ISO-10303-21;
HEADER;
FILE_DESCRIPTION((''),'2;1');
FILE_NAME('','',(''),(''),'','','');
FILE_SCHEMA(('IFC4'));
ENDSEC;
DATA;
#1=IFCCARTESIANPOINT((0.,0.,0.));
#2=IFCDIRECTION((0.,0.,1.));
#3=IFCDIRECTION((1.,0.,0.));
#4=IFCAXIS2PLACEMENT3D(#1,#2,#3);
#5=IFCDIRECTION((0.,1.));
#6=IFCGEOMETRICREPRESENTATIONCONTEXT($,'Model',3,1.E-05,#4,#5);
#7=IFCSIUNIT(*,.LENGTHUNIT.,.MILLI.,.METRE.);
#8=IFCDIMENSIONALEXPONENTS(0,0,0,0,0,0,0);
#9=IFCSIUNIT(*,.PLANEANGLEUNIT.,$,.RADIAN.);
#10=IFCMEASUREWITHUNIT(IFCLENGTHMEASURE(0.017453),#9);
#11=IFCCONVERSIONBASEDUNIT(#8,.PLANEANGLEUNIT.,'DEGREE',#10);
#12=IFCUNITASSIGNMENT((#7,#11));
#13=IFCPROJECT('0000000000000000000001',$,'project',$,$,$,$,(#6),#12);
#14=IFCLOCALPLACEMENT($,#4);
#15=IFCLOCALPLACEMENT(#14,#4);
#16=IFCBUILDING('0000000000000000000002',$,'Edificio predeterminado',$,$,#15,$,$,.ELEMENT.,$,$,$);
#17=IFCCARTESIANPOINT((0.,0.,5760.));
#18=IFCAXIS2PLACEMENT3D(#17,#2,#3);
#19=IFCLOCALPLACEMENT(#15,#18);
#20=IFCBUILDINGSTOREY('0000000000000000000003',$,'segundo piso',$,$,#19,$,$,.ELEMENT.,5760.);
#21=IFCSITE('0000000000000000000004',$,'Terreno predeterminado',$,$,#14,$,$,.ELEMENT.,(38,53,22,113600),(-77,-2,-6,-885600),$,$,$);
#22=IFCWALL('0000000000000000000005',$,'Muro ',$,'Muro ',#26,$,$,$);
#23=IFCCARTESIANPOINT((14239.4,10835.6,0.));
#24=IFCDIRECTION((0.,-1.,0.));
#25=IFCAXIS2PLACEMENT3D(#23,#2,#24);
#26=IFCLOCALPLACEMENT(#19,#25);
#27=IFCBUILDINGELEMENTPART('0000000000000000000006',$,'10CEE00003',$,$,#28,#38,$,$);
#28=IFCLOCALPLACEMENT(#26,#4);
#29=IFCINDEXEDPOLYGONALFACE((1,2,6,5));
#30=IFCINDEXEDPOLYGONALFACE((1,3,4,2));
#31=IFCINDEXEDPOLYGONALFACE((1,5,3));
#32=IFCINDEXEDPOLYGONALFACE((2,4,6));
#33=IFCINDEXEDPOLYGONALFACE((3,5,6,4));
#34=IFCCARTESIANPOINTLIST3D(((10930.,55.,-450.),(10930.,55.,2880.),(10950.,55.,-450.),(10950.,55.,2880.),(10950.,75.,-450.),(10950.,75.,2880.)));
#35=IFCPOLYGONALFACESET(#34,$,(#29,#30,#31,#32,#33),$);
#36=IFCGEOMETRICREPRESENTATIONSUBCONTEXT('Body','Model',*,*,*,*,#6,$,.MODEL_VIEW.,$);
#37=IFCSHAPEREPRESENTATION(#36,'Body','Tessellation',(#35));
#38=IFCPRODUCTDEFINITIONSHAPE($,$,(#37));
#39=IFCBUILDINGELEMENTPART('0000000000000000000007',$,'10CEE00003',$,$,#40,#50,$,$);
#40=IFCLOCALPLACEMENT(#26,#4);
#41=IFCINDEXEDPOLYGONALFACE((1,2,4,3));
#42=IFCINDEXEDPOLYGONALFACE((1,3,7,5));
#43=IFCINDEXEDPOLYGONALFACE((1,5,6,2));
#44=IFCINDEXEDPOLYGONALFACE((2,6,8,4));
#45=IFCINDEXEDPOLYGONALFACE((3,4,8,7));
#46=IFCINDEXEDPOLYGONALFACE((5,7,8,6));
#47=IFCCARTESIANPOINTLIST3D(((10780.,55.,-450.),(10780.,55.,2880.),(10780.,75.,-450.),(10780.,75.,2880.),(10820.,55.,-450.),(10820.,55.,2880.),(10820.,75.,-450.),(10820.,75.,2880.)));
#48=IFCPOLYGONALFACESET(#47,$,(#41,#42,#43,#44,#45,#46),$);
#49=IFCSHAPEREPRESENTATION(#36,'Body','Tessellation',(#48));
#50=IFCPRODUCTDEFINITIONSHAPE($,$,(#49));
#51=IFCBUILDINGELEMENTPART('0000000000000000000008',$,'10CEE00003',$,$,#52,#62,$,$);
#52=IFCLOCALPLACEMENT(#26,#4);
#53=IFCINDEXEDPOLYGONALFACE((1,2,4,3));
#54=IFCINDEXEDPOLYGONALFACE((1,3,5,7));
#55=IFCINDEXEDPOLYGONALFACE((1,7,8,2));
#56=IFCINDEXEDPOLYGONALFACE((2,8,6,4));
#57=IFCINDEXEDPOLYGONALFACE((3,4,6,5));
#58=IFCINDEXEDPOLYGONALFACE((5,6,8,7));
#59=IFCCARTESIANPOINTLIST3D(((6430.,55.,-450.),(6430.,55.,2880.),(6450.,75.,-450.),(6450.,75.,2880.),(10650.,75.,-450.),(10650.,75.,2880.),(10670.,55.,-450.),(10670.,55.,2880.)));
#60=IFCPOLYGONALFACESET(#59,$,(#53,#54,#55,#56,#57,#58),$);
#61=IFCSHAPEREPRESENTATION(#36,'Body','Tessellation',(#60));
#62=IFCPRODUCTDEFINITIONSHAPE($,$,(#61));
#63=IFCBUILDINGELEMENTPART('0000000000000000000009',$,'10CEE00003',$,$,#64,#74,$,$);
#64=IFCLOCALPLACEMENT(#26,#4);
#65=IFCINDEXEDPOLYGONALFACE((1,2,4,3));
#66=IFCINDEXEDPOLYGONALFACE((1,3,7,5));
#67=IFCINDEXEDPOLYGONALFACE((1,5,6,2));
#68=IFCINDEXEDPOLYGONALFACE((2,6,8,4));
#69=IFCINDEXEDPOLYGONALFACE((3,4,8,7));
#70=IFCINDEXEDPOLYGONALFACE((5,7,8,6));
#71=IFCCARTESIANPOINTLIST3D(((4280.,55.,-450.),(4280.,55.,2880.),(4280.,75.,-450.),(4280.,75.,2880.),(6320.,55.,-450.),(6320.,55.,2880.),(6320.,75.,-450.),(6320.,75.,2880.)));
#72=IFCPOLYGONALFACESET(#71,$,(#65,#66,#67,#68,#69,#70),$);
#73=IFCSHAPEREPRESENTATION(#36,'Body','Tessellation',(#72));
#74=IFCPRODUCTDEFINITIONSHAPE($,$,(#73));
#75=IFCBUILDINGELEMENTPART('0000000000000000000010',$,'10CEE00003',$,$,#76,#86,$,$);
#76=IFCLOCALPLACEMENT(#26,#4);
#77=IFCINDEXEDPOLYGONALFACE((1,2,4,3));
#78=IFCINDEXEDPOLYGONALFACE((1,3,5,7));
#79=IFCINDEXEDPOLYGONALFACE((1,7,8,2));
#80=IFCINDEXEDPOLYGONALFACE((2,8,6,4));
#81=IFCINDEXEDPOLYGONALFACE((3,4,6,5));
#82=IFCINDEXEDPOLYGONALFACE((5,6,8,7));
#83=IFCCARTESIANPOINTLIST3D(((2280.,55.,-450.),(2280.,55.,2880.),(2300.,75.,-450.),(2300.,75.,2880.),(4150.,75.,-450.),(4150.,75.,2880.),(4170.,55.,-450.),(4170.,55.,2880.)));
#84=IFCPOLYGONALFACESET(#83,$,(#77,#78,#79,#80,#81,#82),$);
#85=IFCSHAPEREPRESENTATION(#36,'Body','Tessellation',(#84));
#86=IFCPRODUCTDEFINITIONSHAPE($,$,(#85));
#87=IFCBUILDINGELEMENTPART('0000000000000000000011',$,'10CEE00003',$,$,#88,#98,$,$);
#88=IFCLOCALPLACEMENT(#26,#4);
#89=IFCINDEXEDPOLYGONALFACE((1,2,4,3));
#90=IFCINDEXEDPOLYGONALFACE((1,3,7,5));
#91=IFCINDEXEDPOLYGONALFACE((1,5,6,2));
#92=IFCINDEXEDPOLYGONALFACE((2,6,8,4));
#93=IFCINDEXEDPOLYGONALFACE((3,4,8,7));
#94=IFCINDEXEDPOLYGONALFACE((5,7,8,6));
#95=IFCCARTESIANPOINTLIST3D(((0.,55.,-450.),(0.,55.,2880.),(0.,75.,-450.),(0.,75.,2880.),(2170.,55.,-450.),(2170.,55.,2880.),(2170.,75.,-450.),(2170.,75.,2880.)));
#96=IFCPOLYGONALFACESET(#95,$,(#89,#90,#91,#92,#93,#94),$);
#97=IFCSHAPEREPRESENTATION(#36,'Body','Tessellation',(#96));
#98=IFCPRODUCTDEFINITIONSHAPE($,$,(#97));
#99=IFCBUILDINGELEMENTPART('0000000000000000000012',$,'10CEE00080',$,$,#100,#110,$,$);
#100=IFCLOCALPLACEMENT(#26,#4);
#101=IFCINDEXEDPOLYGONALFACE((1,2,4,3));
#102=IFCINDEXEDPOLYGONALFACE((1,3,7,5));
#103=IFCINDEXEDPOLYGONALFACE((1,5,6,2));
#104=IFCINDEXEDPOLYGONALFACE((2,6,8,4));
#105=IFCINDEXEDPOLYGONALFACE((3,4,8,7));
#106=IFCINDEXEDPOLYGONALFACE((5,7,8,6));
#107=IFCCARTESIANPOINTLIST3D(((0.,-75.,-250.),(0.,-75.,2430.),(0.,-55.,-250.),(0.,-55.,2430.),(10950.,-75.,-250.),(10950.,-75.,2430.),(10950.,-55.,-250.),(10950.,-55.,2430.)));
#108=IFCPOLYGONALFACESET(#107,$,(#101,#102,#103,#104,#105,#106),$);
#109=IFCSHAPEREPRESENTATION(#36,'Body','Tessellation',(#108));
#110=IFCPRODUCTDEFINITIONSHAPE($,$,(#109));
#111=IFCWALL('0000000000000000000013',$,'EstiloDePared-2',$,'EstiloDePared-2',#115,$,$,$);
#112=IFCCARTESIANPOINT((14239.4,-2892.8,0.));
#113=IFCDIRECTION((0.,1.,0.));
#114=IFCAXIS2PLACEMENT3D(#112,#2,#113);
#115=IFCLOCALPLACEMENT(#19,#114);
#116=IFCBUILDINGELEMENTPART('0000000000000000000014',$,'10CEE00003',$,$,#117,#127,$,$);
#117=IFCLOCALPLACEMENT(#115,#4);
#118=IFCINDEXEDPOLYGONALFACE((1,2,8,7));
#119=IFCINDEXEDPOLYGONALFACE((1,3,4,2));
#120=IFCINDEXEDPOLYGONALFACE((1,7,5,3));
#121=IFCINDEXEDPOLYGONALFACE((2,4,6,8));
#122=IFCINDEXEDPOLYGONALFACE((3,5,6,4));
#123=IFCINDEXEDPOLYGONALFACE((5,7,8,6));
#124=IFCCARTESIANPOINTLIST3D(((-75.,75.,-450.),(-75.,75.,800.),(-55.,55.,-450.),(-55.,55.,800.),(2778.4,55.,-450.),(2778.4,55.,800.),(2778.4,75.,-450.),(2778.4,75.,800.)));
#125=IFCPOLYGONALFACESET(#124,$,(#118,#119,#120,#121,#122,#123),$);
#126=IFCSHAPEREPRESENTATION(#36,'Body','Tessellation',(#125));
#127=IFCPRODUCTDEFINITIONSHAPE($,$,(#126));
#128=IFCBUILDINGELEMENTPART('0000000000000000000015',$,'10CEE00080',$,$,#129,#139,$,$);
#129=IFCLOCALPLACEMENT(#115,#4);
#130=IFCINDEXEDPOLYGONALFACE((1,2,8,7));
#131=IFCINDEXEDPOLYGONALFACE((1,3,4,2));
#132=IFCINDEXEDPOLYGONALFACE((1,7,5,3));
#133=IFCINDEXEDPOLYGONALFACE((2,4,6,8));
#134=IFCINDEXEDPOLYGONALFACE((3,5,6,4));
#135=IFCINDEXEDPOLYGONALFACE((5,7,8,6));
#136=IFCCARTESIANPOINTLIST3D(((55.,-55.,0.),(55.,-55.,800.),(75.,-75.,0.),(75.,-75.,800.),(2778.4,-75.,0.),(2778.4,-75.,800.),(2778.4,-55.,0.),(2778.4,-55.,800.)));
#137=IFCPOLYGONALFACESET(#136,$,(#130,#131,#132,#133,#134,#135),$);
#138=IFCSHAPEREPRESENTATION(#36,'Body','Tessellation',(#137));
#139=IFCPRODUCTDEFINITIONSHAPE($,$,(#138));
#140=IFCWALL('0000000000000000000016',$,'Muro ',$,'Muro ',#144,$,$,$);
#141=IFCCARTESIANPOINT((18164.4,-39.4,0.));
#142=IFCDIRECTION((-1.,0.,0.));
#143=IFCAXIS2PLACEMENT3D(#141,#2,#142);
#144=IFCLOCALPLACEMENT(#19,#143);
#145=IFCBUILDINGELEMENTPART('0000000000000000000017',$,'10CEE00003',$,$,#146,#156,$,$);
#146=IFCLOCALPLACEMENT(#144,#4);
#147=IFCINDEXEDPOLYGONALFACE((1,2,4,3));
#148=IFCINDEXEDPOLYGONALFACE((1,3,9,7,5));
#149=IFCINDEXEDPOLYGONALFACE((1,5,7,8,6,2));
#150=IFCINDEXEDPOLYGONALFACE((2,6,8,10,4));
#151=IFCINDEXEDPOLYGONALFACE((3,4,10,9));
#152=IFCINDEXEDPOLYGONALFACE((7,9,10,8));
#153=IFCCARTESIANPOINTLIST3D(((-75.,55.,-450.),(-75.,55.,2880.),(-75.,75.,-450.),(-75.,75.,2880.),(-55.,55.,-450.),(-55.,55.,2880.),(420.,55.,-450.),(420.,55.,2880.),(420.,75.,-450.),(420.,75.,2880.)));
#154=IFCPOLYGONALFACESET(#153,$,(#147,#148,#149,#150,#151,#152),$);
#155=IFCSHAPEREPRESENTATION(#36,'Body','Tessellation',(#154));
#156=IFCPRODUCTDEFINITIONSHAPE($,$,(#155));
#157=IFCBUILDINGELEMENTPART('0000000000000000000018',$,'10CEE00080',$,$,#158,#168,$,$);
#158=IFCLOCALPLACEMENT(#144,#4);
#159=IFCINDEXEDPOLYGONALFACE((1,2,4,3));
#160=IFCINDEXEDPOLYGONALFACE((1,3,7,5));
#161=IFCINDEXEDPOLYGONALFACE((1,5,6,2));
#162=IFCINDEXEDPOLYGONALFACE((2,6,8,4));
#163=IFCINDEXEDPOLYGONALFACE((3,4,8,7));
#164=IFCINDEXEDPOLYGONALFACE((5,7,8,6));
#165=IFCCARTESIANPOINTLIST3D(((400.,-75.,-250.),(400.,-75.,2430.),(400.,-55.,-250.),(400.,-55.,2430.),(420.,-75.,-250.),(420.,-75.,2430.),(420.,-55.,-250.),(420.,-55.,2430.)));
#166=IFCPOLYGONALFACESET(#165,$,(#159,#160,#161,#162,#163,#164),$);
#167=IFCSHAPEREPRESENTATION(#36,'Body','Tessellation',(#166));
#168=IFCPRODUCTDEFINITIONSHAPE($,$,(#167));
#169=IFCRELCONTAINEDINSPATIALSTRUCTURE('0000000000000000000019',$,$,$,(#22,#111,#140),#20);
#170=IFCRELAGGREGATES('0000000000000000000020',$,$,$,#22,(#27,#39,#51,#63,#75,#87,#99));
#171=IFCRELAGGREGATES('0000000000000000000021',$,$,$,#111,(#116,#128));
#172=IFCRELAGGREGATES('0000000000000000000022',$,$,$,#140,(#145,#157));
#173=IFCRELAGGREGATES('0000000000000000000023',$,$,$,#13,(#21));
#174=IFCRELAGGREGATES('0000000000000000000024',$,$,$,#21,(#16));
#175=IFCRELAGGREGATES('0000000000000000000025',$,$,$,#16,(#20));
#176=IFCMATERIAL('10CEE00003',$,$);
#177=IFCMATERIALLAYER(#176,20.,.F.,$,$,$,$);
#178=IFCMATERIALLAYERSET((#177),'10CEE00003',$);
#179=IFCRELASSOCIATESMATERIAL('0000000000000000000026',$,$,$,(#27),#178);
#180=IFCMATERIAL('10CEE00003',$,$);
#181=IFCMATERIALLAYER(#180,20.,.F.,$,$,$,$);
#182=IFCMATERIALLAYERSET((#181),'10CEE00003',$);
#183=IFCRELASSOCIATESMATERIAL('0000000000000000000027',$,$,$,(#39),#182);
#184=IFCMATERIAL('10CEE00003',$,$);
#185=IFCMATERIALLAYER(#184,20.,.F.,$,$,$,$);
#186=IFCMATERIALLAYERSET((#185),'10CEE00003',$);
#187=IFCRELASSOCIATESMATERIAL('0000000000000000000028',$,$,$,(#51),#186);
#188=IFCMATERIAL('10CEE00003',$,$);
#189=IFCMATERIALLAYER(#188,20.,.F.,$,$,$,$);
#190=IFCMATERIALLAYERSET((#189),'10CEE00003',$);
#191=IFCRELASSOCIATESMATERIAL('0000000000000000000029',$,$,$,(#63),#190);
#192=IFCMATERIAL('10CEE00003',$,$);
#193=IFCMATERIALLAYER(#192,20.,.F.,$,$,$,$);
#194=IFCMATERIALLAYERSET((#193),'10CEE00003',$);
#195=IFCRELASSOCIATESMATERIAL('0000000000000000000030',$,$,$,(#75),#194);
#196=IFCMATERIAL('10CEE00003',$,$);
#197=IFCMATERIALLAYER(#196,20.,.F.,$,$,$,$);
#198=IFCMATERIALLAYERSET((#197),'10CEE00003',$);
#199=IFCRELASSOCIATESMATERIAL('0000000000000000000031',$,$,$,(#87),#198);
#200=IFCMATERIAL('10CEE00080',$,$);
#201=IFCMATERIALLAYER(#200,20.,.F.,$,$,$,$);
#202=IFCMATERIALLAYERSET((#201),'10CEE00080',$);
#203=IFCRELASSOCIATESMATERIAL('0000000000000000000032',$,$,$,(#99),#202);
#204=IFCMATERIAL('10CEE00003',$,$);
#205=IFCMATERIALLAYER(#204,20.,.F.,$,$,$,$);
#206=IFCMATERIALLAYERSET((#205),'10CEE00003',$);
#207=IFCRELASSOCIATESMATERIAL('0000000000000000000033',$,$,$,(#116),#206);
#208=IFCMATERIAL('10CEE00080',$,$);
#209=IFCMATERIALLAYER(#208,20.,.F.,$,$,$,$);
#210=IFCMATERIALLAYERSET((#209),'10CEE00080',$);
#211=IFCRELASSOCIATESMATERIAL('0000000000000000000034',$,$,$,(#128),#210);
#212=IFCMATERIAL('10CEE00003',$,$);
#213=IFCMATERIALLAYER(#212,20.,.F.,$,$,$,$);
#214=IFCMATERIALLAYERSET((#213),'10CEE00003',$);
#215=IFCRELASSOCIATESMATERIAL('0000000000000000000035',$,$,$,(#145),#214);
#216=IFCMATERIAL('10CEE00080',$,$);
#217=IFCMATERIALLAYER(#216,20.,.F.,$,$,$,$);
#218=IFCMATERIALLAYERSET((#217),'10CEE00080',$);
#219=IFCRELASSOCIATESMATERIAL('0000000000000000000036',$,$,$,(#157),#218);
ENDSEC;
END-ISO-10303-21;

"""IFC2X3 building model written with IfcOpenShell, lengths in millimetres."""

from ifc_helpers import new_model, entity, si_unit, converted_unit, direction, frame, origin_with_axes, place, context, subcontext, project, spatial, polyline, outline, extrude, material, layer, layer_set, layer_usage, element, aggregate, save


model = new_model("IFC2X3")

# Units and contexts
model_context = context("Model", 3, precision=1e-05, world=origin_with_axes(), true_north=direction((0.0, 1.0)))
body_context = subcontext(model_context, "Body", "Model", "MODEL_VIEW")
ifc_project = project(units=[si_unit("LENGTHUNIT", "METRE", prefix="MILLI"), converted_unit("PLANEANGLEUNIT", "DEGREE", entity("IfcLengthMeasure", 0.017453), si_unit("PLANEANGLEUNIT", "RADIAN"), dimensions=[0, 0, 0, 0, 0, 0, 0])], contexts=[model_context])

# Site, building, storey
site_placement = place(None, origin_with_axes())
site = spatial("IfcSite", under=ifc_project, at=site_placement, Name="Terreno predeterminado", CompositionType="ELEMENT", RefLatitude=(38, 53, 22, 113600), RefLongitude=(-77, -2, -6, -885600))
building_placement = place(site_placement, origin_with_axes())
building = spatial("IfcBuilding", under=site, at=building_placement, Name="Edificio predeterminado", CompositionType="ELEMENT")
storey_placement = place(building_placement, frame((0.0, 0.0, 5760.0), z_axis=(0.0, 0.0, 1.0), x_axis=(1.0, 0.0, 0.0)))
storey = spatial("IfcBuildingStorey", under=building, at=storey_placement, Name="segundo piso", CompositionType="ELEMENT", Elevation=5760.0)

# Walls, building element parts
wall_1_placement = place(storey_placement, frame((14239.4, 10835.6, 0.0), z_axis=(0.0, 0.0, 1.0), x_axis=(0.0, -1.0, 0.0)))
wall_1 = element("IfcWall", 1, at=wall_1_placement, inside=storey, Name="Muro ", ObjectType="Muro ")
ifc_material_1 = material(Name="10CEE00003")
ifc_layer_1 = layer(ifc_material_1, 20.0, ventilated=False)
ifc_layer_set_1 = layer_set([ifc_layer_1], Name="10CEE00003")
ifc_layer_usage_1 = layer_usage(ifc_layer_set_1, "AXIS2", "NEGATIVE", -75.0)
building_element_part_1_placement = place(wall_1_placement, origin_with_axes())
building_element_part_1 = element("IfcBuildingElementPart", 2, at=building_element_part_1_placement, material=ifc_layer_usage_1, Name="10CEE00003", context=body_context, shape_type="SweptSolid", body=[
    extrude(outline(polyline([(10950.0, 75.0), (10950.0, 55.0), (10930.0, 55.0), (10950.0, 75.0)])), frame((0.0, 0.0, -450.0), z_axis=(0.0, 0.0, 1.0), x_axis=(1.0, 0.0, 0.0)), (0.0, 0.0, 1.0), 3330.0),
])
ifc_material_2 = material(Name="10CEE00003")
ifc_layer_2 = layer(ifc_material_2, 20.0, ventilated=False)
ifc_layer_set_2 = layer_set([ifc_layer_2], Name="10CEE00003")
ifc_layer_usage_2 = layer_usage(ifc_layer_set_2, "AXIS2", "NEGATIVE", -75.0)
building_element_part_2_placement = place(wall_1_placement, origin_with_axes())
building_element_part_2 = element("IfcBuildingElementPart", 3, at=building_element_part_2_placement, material=ifc_layer_usage_2, Name="10CEE00003", context=body_context, shape_type="SweptSolid", body=[
    extrude(outline(polyline([(10820.0, 75.0), (10820.0, 55.0), (10780.0, 55.0), (10780.0, 75.0), (10820.0, 75.0)])), frame((0.0, 0.0, -450.0), z_axis=(0.0, 0.0, 1.0), x_axis=(1.0, 0.0, 0.0)), (0.0, 0.0, 1.0), 3330.0),
])
ifc_material_3 = material(Name="10CEE00003")
ifc_layer_3 = layer(ifc_material_3, 20.0, ventilated=False)
ifc_layer_set_3 = layer_set([ifc_layer_3], Name="10CEE00003")
ifc_layer_usage_3 = layer_usage(ifc_layer_set_3, "AXIS2", "NEGATIVE", -75.0)
building_element_part_3_placement = place(wall_1_placement, origin_with_axes())
building_element_part_3 = element("IfcBuildingElementPart", 4, at=building_element_part_3_placement, material=ifc_layer_usage_3, Name="10CEE00003", context=body_context, shape_type="SweptSolid", body=[
    extrude(outline(polyline([(10650.0, 75.0), (10670.0, 55.0), (6430.0, 55.0), (6450.0, 75.0), (10650.0, 75.0)])), frame((0.0, 0.0, -450.0), z_axis=(0.0, 0.0, 1.0), x_axis=(1.0, 0.0, 0.0)), (0.0, 0.0, 1.0), 3330.0),
])
ifc_material_4 = material(Name="10CEE00003")
ifc_layer_4 = layer(ifc_material_4, 20.0, ventilated=False)
ifc_layer_set_4 = layer_set([ifc_layer_4], Name="10CEE00003")
ifc_layer_usage_4 = layer_usage(ifc_layer_set_4, "AXIS2", "NEGATIVE", -75.0)
building_element_part_4_placement = place(wall_1_placement, origin_with_axes())
building_element_part_4 = element("IfcBuildingElementPart", 5, at=building_element_part_4_placement, material=ifc_layer_usage_4, Name="10CEE00003", context=body_context, shape_type="SweptSolid", body=[
    extrude(outline(polyline([(4280.0, 75.0), (6320.0, 75.0), (6320.0, 55.0), (4280.0, 55.0), (4280.0, 75.0)])), frame((0.0, 0.0, -450.0), z_axis=(0.0, 0.0, 1.0), x_axis=(1.0, 0.0, 0.0)), (0.0, 0.0, 1.0), 3330.0),
])
ifc_material_5 = material(Name="10CEE00003")
ifc_layer_5 = layer(ifc_material_5, 20.0, ventilated=False)
ifc_layer_set_5 = layer_set([ifc_layer_5], Name="10CEE00003")
ifc_layer_usage_5 = layer_usage(ifc_layer_set_5, "AXIS2", "NEGATIVE", -75.0)
building_element_part_5_placement = place(wall_1_placement, origin_with_axes())
building_element_part_5 = element("IfcBuildingElementPart", 6, at=building_element_part_5_placement, material=ifc_layer_usage_5, Name="10CEE00003", context=body_context, shape_type="SweptSolid", body=[
    extrude(outline(polyline([(4150.0, 75.0), (4170.0, 55.0), (2280.0, 55.0), (2300.0, 75.0), (4150.0, 75.0)])), frame((0.0, 0.0, -450.0), z_axis=(0.0, 0.0, 1.0), x_axis=(1.0, 0.0, 0.0)), (0.0, 0.0, 1.0), 3330.0),
])
ifc_material_6 = material(Name="10CEE00003")
ifc_layer_6 = layer(ifc_material_6, 20.0, ventilated=False)
ifc_layer_set_6 = layer_set([ifc_layer_6], Name="10CEE00003")
ifc_layer_usage_6 = layer_usage(ifc_layer_set_6, "AXIS2", "NEGATIVE", -75.0)
building_element_part_6_placement = place(wall_1_placement, origin_with_axes())
building_element_part_6 = element("IfcBuildingElementPart", 7, at=building_element_part_6_placement, material=ifc_layer_usage_6, Name="10CEE00003", context=body_context, shape_type="SweptSolid", body=[
    extrude(outline(polyline([(2170.0, 75.0), (2170.0, 55.0), (0.0, 55.0), (0.0, 75.0), (2170.0, 75.0)])), frame((0.0, 0.0, -450.0), z_axis=(0.0, 0.0, 1.0), x_axis=(1.0, 0.0, 0.0)), (0.0, 0.0, 1.0), 3330.0),
])
ifc_material_7 = material(Name="10CEE00080")
ifc_layer_7 = layer(ifc_material_7, 20.0, ventilated=False)
ifc_layer_set_7 = layer_set([ifc_layer_7], Name="10CEE00080")
ifc_layer_usage_7 = layer_usage(ifc_layer_set_7, "AXIS2", "NEGATIVE", 55.0)
building_element_part_7_placement = place(wall_1_placement, origin_with_axes())
building_element_part_7 = element("IfcBuildingElementPart", 8, at=building_element_part_7_placement, material=ifc_layer_usage_7, Name="10CEE00080", context=body_context, shape_type="SweptSolid", body=[
    extrude(outline(polyline([(10950.0, -55.0), (10950.0, -75.0), (0.0, -75.0), (0.0, -55.0), (10950.0, -55.0)])), frame((0.0, 0.0, -250.0), z_axis=(0.0, 0.0, 1.0), x_axis=(1.0, 0.0, 0.0)), (0.0, 0.0, 1.0), 2680.0),
])
aggregate(wall_1, [building_element_part_1, building_element_part_2, building_element_part_3, building_element_part_4, building_element_part_5, building_element_part_6, building_element_part_7])
wall_2_placement = place(storey_placement, frame((14239.4, -2892.8, 0.0), z_axis=(0.0, 0.0, 1.0), x_axis=(0.0, 1.0, 0.0)))
wall_2 = element("IfcWall", 9, at=wall_2_placement, inside=storey, Name="EstiloDePared-2", ObjectType="EstiloDePared-2")
ifc_material_8 = material(Name="10CEE00003")
ifc_layer_8 = layer(ifc_material_8, 20.0, ventilated=False)
ifc_layer_set_8 = layer_set([ifc_layer_8], Name="10CEE00003")
ifc_layer_usage_8 = layer_usage(ifc_layer_set_8, "AXIS2", "NEGATIVE", -75.0)
building_element_part_8_placement = place(wall_2_placement, origin_with_axes())
building_element_part_8 = element("IfcBuildingElementPart", 10, at=building_element_part_8_placement, material=ifc_layer_usage_8, Name="10CEE00003", context=body_context, shape_type="SweptSolid", body=[
    extrude(outline(polyline([(2778.4, 75.0), (2778.4, 55.0), (-55.0, 55.0), (-75.0, 75.0), (2778.4, 75.0)])), frame((0.0, 0.0, -450.0), z_axis=(0.0, 0.0, 1.0), x_axis=(1.0, 0.0, 0.0)), (0.0, 0.0, 1.0), 1250.0),
])
ifc_material_9 = material(Name="10CEE00080")
ifc_layer_9 = layer(ifc_material_9, 20.0, ventilated=False)
ifc_layer_set_9 = layer_set([ifc_layer_9], Name="10CEE00080")
ifc_layer_usage_9 = layer_usage(ifc_layer_set_9, "AXIS2", "NEGATIVE", 55.0)
building_element_part_9_placement = place(wall_2_placement, origin_with_axes())
building_element_part_9 = element("IfcBuildingElementPart", 11, at=building_element_part_9_placement, material=ifc_layer_usage_9, Name="10CEE00080", context=body_context, shape_type="SweptSolid", body=[
    extrude(outline(polyline([(2778.4, -55.0), (2778.4, -75.0), (75.0, -75.0), (55.0, -55.0), (2778.4, -55.0)])), origin_with_axes(), (0.0, 0.0, 1.0), 800.0),
])
aggregate(wall_2, [building_element_part_8, building_element_part_9])
wall_3_placement = place(storey_placement, frame((18164.4, -39.4, 0.0), z_axis=(0.0, 0.0, 1.0), x_axis=(-1.0, 0.0, 0.0)))
wall_3 = element("IfcWall", 12, at=wall_3_placement, inside=storey, Name="Muro ", ObjectType="Muro ")
ifc_material_10 = material(Name="10CEE00003")
ifc_layer_10 = layer(ifc_material_10, 20.0, ventilated=False)
ifc_layer_set_10 = layer_set([ifc_layer_10], Name="10CEE00003")
ifc_layer_usage_10 = layer_usage(ifc_layer_set_10, "AXIS2", "NEGATIVE", -75.0)
building_element_part_10_placement = place(wall_3_placement, origin_with_axes())
building_element_part_10 = element("IfcBuildingElementPart", 13, at=building_element_part_10_placement, material=ifc_layer_usage_10, Name="10CEE00003", context=body_context, shape_type="SweptSolid", body=[
    extrude(outline(polyline([(420.0, 75.0), (420.0, 55.0), (-55.0, 55.0), (-75.0, 55.0), (-75.0, 75.0), (420.0, 75.0)])), frame((0.0, 0.0, -450.0), z_axis=(0.0, 0.0, 1.0), x_axis=(1.0, 0.0, 0.0)), (0.0, 0.0, 1.0), 3330.0),
])
ifc_material_11 = material(Name="10CEE00080")
ifc_layer_11 = layer(ifc_material_11, 20.0, ventilated=False)
ifc_layer_set_11 = layer_set([ifc_layer_11], Name="10CEE00080")
ifc_layer_usage_11 = layer_usage(ifc_layer_set_11, "AXIS2", "NEGATIVE", 55.0)
building_element_part_11_placement = place(wall_3_placement, origin_with_axes())
building_element_part_11 = element("IfcBuildingElementPart", 14, at=building_element_part_11_placement, material=ifc_layer_usage_11, Name="10CEE00080", context=body_context, shape_type="SweptSolid", body=[
    extrude(outline(polyline([(420.0, -55.0), (420.0, -75.0), (400.0, -75.0), (400.0, -55.0), (420.0, -55.0)])), frame((0.0, 0.0, -250.0), z_axis=(0.0, 0.0, 1.0), x_axis=(1.0, 0.0, 0.0)), (0.0, 0.0, 1.0), 2680.0),
])
aggregate(wall_3, [building_element_part_10, building_element_part_11])

save(model, "model.ifc")
